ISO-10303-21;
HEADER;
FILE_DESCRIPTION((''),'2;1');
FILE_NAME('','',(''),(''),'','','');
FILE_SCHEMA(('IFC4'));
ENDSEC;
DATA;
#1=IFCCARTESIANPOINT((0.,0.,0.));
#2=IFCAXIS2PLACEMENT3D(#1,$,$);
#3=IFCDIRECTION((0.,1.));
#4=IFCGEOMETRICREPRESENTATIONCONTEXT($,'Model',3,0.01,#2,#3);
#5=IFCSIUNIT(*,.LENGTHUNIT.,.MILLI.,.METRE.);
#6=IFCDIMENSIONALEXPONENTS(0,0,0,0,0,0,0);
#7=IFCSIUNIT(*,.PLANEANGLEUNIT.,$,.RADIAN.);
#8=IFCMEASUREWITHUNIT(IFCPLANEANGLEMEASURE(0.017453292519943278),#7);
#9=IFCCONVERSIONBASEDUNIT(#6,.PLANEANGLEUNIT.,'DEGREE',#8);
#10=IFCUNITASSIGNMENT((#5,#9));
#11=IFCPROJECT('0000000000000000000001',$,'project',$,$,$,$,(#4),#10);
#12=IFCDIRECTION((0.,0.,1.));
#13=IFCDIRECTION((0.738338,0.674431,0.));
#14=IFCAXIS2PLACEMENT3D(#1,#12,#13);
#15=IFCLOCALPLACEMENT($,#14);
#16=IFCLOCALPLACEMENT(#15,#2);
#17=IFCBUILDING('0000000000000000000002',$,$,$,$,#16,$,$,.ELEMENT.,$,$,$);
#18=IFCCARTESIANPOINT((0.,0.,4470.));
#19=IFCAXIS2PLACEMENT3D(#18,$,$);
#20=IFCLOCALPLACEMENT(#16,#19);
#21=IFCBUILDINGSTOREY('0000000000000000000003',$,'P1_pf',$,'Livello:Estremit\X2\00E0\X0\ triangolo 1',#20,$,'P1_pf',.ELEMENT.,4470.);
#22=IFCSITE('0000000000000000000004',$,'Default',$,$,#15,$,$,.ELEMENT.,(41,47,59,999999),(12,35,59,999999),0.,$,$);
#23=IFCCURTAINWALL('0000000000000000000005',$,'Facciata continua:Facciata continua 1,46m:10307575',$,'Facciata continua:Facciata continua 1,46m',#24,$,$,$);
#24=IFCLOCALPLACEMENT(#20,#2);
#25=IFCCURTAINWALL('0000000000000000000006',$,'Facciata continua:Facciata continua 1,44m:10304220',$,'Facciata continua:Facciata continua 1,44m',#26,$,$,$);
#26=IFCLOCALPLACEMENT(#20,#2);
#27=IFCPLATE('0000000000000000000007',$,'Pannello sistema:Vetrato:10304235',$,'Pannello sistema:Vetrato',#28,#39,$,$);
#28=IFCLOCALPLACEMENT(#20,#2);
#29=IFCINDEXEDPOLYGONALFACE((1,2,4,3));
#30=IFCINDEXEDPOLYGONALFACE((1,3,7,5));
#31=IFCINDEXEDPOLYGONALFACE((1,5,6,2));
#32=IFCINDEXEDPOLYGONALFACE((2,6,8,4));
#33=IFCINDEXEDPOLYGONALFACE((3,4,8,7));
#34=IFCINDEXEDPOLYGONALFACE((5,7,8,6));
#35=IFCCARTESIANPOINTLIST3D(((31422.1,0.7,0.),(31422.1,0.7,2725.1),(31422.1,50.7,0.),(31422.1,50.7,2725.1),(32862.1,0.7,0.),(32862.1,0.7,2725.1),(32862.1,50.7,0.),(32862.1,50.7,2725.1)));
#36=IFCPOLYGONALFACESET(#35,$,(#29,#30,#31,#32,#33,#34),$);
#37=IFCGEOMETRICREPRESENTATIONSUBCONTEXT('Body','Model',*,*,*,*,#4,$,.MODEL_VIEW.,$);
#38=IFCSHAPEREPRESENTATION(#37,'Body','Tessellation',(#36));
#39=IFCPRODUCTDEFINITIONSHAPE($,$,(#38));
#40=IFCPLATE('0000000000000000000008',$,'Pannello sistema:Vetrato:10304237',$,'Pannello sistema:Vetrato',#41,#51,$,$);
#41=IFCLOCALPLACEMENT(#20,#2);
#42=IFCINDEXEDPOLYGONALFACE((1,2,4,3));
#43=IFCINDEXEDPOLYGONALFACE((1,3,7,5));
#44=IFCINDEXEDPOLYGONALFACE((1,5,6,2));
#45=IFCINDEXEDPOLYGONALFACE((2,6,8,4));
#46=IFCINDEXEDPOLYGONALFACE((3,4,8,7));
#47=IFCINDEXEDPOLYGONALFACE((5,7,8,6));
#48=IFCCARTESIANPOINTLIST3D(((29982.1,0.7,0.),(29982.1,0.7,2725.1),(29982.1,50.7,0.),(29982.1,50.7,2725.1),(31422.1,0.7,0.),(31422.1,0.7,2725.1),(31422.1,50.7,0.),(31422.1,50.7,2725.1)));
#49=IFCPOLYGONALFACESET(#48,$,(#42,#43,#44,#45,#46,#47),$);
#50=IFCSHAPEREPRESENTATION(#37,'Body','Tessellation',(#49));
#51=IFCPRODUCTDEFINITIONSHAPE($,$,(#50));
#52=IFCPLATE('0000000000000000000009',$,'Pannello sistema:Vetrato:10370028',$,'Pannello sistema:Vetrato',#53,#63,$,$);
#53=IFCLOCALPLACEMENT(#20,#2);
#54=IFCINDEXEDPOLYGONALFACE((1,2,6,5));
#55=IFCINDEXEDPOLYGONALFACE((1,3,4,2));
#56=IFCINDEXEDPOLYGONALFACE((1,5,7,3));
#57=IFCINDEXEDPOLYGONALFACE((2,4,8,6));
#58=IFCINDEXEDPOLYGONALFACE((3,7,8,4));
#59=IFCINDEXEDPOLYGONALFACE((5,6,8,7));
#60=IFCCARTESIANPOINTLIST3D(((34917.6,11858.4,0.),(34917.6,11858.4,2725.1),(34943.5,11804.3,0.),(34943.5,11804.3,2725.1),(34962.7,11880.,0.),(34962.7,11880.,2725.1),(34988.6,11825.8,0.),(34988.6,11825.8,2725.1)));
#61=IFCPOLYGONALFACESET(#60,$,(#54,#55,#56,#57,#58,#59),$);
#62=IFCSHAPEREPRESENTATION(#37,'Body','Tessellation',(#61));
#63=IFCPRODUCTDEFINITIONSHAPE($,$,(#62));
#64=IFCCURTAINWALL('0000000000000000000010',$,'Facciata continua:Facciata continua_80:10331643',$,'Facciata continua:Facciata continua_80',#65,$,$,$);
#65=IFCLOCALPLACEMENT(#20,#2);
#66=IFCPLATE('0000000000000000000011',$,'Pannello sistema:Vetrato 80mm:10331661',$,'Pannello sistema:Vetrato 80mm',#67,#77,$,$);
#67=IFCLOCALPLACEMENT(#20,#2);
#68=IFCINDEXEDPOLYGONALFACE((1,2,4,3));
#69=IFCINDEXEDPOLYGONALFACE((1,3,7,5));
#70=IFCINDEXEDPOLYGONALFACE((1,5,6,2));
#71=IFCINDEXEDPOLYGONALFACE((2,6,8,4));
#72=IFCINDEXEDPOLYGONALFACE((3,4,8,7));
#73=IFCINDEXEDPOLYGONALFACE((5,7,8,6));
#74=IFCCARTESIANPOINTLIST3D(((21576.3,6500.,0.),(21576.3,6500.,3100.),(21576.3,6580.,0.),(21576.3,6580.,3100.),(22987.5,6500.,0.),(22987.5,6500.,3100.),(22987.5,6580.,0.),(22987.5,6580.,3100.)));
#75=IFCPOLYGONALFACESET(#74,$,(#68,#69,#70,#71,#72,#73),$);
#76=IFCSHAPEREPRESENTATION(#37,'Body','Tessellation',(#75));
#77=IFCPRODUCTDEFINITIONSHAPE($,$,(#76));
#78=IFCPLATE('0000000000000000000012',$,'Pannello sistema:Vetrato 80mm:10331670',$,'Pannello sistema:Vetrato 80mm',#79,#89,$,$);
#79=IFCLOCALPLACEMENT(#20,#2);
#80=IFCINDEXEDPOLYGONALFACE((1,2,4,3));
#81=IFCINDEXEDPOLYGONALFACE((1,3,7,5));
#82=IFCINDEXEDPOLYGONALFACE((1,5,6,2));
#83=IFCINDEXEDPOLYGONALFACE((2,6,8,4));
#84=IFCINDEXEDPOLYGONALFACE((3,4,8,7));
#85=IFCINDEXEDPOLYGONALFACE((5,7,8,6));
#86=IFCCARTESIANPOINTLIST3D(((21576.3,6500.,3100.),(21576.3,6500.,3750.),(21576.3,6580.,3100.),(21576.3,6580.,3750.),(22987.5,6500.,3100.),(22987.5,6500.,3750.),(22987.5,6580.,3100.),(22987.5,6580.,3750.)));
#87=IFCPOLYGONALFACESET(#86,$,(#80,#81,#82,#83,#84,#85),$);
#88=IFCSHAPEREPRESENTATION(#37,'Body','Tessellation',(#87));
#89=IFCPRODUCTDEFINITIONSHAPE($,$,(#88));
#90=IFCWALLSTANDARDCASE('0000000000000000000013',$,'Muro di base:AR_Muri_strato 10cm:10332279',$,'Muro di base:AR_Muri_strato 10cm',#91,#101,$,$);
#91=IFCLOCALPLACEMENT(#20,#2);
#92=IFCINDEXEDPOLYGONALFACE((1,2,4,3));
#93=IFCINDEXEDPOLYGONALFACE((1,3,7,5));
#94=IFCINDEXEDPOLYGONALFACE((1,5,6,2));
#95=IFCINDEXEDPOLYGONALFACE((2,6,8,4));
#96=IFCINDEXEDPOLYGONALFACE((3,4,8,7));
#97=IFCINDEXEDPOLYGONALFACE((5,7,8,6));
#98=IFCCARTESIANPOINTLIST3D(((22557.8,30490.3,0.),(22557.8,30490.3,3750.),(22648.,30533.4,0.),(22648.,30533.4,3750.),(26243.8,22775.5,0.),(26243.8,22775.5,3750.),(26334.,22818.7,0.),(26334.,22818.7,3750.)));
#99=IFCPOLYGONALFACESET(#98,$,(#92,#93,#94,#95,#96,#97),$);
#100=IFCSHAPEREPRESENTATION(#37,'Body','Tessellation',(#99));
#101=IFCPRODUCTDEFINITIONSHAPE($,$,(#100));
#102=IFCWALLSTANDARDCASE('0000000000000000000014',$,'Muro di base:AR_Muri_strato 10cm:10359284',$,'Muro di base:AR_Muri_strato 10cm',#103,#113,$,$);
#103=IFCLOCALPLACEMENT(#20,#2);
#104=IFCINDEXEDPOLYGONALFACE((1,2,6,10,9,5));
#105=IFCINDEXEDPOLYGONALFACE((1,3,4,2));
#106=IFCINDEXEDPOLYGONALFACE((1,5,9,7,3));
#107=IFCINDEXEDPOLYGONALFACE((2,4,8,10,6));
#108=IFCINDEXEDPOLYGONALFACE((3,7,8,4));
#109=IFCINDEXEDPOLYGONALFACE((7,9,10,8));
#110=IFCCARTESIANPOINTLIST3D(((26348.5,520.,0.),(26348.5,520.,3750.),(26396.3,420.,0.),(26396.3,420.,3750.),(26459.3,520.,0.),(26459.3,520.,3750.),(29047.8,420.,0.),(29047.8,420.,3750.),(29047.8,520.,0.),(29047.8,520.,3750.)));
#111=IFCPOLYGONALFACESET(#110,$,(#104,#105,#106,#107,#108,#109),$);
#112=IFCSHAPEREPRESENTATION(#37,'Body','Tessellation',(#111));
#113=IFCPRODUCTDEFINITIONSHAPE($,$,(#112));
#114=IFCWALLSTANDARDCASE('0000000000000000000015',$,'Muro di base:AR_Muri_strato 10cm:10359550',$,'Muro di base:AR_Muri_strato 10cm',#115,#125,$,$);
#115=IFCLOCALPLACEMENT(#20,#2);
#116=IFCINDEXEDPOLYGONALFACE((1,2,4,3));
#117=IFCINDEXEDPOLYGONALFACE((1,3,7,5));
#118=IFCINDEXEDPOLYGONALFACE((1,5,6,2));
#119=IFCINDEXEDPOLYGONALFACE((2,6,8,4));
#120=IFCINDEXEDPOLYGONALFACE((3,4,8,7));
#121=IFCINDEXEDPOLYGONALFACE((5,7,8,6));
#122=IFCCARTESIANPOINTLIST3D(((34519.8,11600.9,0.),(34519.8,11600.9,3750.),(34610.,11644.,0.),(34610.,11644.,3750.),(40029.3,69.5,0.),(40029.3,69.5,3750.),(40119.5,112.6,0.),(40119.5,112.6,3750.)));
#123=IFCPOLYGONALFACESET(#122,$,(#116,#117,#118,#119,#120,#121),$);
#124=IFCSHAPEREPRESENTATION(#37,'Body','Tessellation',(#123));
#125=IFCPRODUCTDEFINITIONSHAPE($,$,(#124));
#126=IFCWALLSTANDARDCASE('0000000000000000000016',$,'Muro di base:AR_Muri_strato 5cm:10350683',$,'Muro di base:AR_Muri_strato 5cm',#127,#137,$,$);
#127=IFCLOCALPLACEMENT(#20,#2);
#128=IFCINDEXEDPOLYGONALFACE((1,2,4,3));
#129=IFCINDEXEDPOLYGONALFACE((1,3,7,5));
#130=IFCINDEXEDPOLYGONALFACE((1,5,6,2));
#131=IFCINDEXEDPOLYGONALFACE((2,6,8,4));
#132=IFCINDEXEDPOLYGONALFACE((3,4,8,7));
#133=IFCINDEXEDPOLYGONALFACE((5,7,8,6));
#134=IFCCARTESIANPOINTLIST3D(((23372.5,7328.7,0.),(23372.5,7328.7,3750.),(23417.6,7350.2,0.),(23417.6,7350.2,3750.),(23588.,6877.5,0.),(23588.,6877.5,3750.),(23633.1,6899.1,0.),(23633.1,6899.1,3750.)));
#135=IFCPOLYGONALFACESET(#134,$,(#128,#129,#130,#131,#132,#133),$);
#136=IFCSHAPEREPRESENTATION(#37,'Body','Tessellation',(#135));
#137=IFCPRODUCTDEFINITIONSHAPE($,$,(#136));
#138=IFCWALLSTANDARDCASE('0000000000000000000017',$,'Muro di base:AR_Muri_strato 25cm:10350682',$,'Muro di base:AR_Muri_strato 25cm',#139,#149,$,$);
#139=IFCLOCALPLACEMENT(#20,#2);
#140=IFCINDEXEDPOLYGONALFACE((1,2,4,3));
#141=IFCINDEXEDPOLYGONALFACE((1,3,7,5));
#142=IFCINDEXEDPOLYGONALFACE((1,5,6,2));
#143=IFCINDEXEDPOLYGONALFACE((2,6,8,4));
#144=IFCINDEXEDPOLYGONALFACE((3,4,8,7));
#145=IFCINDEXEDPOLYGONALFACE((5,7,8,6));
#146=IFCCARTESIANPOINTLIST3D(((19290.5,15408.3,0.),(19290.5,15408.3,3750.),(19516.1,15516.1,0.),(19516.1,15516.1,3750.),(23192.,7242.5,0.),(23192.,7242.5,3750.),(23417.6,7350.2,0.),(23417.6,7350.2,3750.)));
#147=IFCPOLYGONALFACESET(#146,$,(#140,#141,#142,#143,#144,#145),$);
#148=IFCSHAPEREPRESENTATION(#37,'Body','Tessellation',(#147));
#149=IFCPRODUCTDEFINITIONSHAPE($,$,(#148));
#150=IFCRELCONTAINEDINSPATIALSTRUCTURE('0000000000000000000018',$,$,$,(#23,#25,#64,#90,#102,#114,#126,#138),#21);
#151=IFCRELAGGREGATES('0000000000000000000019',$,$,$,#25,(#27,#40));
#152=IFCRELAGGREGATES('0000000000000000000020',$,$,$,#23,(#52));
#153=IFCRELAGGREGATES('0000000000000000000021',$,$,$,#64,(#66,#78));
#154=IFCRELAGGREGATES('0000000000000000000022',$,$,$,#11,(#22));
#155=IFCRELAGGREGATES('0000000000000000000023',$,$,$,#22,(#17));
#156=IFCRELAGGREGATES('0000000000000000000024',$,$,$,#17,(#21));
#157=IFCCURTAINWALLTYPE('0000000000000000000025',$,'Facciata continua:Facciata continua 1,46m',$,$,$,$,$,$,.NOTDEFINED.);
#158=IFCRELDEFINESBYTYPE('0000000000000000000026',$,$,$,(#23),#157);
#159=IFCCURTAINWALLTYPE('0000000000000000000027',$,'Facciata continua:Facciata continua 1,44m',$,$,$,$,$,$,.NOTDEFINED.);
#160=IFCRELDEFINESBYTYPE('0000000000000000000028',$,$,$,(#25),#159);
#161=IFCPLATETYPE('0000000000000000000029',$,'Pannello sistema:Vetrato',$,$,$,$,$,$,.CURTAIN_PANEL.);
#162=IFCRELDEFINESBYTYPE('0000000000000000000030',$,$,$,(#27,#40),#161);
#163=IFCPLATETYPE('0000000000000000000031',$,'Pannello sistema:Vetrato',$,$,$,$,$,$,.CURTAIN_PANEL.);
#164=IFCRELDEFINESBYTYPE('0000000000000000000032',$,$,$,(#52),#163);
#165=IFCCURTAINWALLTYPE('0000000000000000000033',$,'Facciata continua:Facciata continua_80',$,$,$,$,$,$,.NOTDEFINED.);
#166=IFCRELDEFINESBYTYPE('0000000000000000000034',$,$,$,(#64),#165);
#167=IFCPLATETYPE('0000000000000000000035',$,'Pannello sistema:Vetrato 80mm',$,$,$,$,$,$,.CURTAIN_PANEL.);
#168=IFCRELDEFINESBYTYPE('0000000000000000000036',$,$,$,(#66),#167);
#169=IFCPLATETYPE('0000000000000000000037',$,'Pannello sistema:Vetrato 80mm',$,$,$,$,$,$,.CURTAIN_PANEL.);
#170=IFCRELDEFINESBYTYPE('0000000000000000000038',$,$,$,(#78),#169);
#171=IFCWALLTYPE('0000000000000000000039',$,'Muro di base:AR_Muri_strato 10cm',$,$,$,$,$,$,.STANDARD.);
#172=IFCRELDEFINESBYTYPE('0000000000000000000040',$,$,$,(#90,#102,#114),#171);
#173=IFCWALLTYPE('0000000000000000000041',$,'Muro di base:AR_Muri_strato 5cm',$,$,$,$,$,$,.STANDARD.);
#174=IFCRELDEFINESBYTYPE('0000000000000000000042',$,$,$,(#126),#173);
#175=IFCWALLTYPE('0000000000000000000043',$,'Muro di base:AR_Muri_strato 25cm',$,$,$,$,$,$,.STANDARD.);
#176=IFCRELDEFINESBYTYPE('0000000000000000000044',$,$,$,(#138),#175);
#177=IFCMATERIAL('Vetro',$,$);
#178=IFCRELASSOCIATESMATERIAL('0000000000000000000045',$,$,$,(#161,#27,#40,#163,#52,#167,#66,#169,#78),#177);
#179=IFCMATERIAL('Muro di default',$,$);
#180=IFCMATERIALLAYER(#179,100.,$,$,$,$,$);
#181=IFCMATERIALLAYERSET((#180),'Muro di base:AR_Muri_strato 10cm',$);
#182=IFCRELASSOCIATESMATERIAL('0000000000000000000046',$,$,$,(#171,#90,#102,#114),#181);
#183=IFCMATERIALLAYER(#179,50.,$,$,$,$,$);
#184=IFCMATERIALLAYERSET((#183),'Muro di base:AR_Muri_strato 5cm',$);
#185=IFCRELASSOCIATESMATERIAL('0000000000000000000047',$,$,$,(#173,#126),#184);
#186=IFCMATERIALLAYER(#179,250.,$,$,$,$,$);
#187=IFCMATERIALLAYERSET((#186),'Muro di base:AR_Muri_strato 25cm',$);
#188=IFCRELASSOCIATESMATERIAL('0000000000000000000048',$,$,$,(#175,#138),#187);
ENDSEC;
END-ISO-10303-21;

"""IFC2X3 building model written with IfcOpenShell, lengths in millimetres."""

from ifc_helpers import new_model, entity, si_unit, converted_unit, direction, frame, frame_2d, origin, origin_2d_with_axis, place, context, subcontext, project, spatial, polyline, rectangle, outline, extrude, source, transform, mapped, material, layer, layer_set, layer_usage, type_object, type_shapes, element, aggregate, save


model = new_model("IFC2X3")

# Units and contexts
model_context = context("Model", 3, precision=0.01, world=origin(), true_north=direction((0.0, 1.0)))
body_context = subcontext(model_context, "Body", "Model", "MODEL_VIEW")
ifc_project = project(units=[si_unit("LENGTHUNIT", "METRE", prefix="MILLI"), converted_unit("PLANEANGLEUNIT", "DEGREE", entity("IfcPlaneAngleMeasure", 0.017453292519943278), si_unit("PLANEANGLEUNIT", "RADIAN"), dimensions=[0, 0, 0, 0, 0, 0, 0])], contexts=[model_context])

# Site, building, storey
site_placement = place(None, frame((0.0, 0.0, 0.0), z_axis=(0.0, 0.0, 1.0), x_axis=(0.738338, 0.674431, 0.0)))
site = spatial("IfcSite", under=ifc_project, at=site_placement, Name="Default", CompositionType="ELEMENT", RefLatitude=(41, 47, 59, 999999), RefLongitude=(12, 35, 59, 999999), RefElevation=0.0)
building_placement = place(site_placement, origin())
building = spatial("IfcBuilding", under=site, at=building_placement, CompositionType="ELEMENT")
storey_placement = place(building_placement, frame((0.0, 0.0, 4470.0)))
storey = spatial("IfcBuildingStorey", under=building, at=storey_placement, Name="P1_pf", ObjectType="Livello:Estremità triangolo 1", LongName="P1_pf", CompositionType="ELEMENT", Elevation=4470.0)

# Curtain walls, plates
curtain_wall_type_1 = type_object("IfcCurtainWallType", Name="Facciata continua:Facciata continua 1,46m", PredefinedType="NOTDEFINED")
curtain_wall_1_placement = place(storey_placement, frame((0.0, 0.0, -4470.0)))
curtain_wall_1 = element("IfcCurtainWall", 1, at=curtain_wall_1_placement, inside=storey, type_object=curtain_wall_type_1, Name="Facciata continua:Facciata continua 1,46m:10307575", ObjectType="Facciata continua:Facciata continua 1,46m")
ifc_material_1 = material(Name="Vetro")
curtain_wall_type_2 = type_object("IfcCurtainWallType", Name="Facciata continua:Facciata continua 1,44m", PredefinedType="NOTDEFINED")
curtain_wall_2_placement = place(storey_placement, frame((0.0, 0.0, -4470.0)))
curtain_wall_2 = element("IfcCurtainWall", 2, at=curtain_wall_2_placement, inside=storey, type_object=curtain_wall_type_2, Name="Facciata continua:Facciata continua 1,44m:10304220", ObjectType="Facciata continua:Facciata continua 1,44m")
plate_type_1 = type_object("IfcPlateType", Name="Pannello sistema:Vetrato", PredefinedType="CURTAIN_PANEL", material=ifc_material_1)
shared_shape_1 = source(origin(), body_context, "Body", "SweptSolid", [
    extrude(rectangle(XDim=50.0, YDim=1440.0, at=origin_2d_with_axis()), frame((0.0, -25.0, 0.0), z_axis=(0.0, 0.0, 1.0), x_axis=(0.0, 1.0, 0.0)), (0.0, 0.0, 1.0), 2725.1),
])
type_shapes(plate_type_1, [shared_shape_1])
plate_1_placement = place(curtain_wall_2_placement, frame((32142.1, 0.7, 4470.0), z_axis=(0.0, 0.0, 1.0), x_axis=(-1.0, 0.0, 0.0)))
plate_1 = element("IfcPlate", 3, at=plate_1_placement, type_object=plate_type_1, material=ifc_material_1, Name="Pannello sistema:Vetrato:10304235", ObjectType="Pannello sistema:Vetrato", context=body_context, shape_type="MappedRepresentation", body=[
    mapped(shared_shape_1, transform((0.0, 0.0, 0.0), scale=1.0)),
])
plate_2_placement = place(curtain_wall_2_placement, frame((30702.1, 0.7, 4470.0), z_axis=(0.0, 0.0, 1.0), x_axis=(-1.0, 0.0, 0.0)))
plate_2 = element("IfcPlate", 4, at=plate_2_placement, type_object=plate_type_1, material=ifc_material_1, Name="Pannello sistema:Vetrato:10304237", ObjectType="Pannello sistema:Vetrato", context=body_context, shape_type="MappedRepresentation", body=[
    mapped(shared_shape_1, transform((0.0, 0.0, 0.0), scale=1.0)),
])
aggregate(curtain_wall_2, [plate_1, plate_2])

# Plate
plate_type_2 = type_object("IfcPlateType", Name="Pannello sistema:Vetrato", PredefinedType="CURTAIN_PANEL", material=ifc_material_1)
shared_shape_2 = source(origin(), body_context, "Body", "SweptSolid", [
    extrude(rectangle(XDim=50.0, YDim=60.0, at=frame_2d((0.0, 0.0), x_axis=(1.0, 0.0))), frame((0.0, -25.0, 0.0), z_axis=(0.0, 0.0, 1.0), x_axis=(0.0, 1.0, 0.0)), (0.0, 0.0, 1.0), 2725.1),
])
type_shapes(plate_type_2, [shared_shape_2])
plate_3_placement = place(curtain_wall_1_placement, frame((34975.6, 11852.9, 4470.0), z_axis=(0.0, 0.0, 1.0), x_axis=(0.431105, -0.902302, 0.0)))
plate_3 = element("IfcPlate", 5, at=plate_3_placement, type_object=plate_type_2, material=ifc_material_1, Name="Pannello sistema:Vetrato:10370028", ObjectType="Pannello sistema:Vetrato", context=body_context, shape_type="MappedRepresentation", body=[
    mapped(shared_shape_2, transform((0.0, 0.0, 0.0), scale=1.0)),
])
aggregate(curtain_wall_1, [plate_3])

# Curtain wall, plates
curtain_wall_type_3 = type_object("IfcCurtainWallType", Name="Facciata continua:Facciata continua_80", PredefinedType="NOTDEFINED")
curtain_wall_3_placement = place(storey_placement, frame((0.0, 0.0, -4470.0)))
curtain_wall_3 = element("IfcCurtainWall", 6, at=curtain_wall_3_placement, inside=storey, type_object=curtain_wall_type_3, Name="Facciata continua:Facciata continua_80:10331643", ObjectType="Facciata continua:Facciata continua_80")
plate_type_3 = type_object("IfcPlateType", Name="Pannello sistema:Vetrato 80mm", PredefinedType="CURTAIN_PANEL", material=ifc_material_1)
shared_shape_3 = source(origin(), body_context, "Body", "SweptSolid", [
    extrude(rectangle(XDim=80.0, YDim=1411.2, at=origin_2d_with_axis()), frame((0.0, -40.0, 0.0), z_axis=(0.0, 0.0, 1.0), x_axis=(0.0, 1.0, 0.0)), (0.0, 0.0, 1.0), 3100.0),
])
type_shapes(plate_type_3, [shared_shape_3])
plate_4_placement = place(curtain_wall_3_placement, frame((22281.9, 6580.0, 4470.0)))
plate_4 = element("IfcPlate", 7, at=plate_4_placement, type_object=plate_type_3, material=ifc_material_1, Name="Pannello sistema:Vetrato 80mm:10331661", ObjectType="Pannello sistema:Vetrato 80mm", context=body_context, shape_type="MappedRepresentation", body=[
    mapped(shared_shape_3, transform((0.0, 0.0, 0.0), scale=1.0)),
])
plate_type_4 = type_object("IfcPlateType", Name="Pannello sistema:Vetrato 80mm", PredefinedType="CURTAIN_PANEL", material=ifc_material_1)
shared_shape_4 = source(origin(), body_context, "Body", "SweptSolid", [
    extrude(rectangle(XDim=80.0, YDim=1411.2, at=origin_2d_with_axis()), frame((0.0, -40.0, 0.0), z_axis=(0.0, 0.0, 1.0), x_axis=(0.0, 1.0, 0.0)), (0.0, 0.0, 1.0), 650.0),
])
type_shapes(plate_type_4, [shared_shape_4])
plate_5_placement = place(curtain_wall_3_placement, frame((22281.9, 6580.0, 7570.0)))
plate_5 = element("IfcPlate", 8, at=plate_5_placement, type_object=plate_type_4, material=ifc_material_1, Name="Pannello sistema:Vetrato 80mm:10331670", ObjectType="Pannello sistema:Vetrato 80mm", context=body_context, shape_type="MappedRepresentation", body=[
    mapped(shared_shape_4, transform((0.0, 0.0, 0.0), scale=1.0)),
])
aggregate(curtain_wall_3, [plate_4, plate_5])

# Walls
ifc_material_2 = material(Name="Muro di default")
ifc_layer_1 = layer(ifc_material_2, 100.0)
ifc_layer_set_1 = layer_set([ifc_layer_1], Name="Muro di base:AR_Muri_strato 10cm")
ifc_layer_usage_1 = layer_usage(ifc_layer_set_1, "AXIS2", "NEGATIVE", 50.0)
wall_type_1 = type_object("IfcWallType", Name="Muro di base:AR_Muri_strato 10cm", PredefinedType="STANDARD", material=ifc_layer_set_1)
wall_1_placement = place(storey_placement, frame((26288.9, 22797.1, 0.0), z_axis=(0.0, 0.0, 1.0), x_axis=(-0.431105, 0.902302, 0.0)))
element("IfcWallStandardCase", 9, at=wall_1_placement, inside=storey, type_object=wall_type_1, material=ifc_layer_usage_1, Name="Muro di base:AR_Muri_strato 10cm:10332279", ObjectType="Muro di base:AR_Muri_strato 10cm", context=body_context, shape_type="SweptSolid", body=[
    extrude(rectangle(XDim=8550.1, YDim=100.0, at=frame_2d((4275.1, 0.0), x_axis=(-1.0, 0.0))), origin(), (0.0, 0.0, 1.0), 3750.0),
])
ifc_layer_usage_2 = layer_usage(ifc_layer_set_1, "AXIS2", "NEGATIVE", 50.0)
wall_2_placement = place(storey_placement, frame((29047.8, 470.0, 0.0), z_axis=(0.0, 0.0, 1.0), x_axis=(-1.0, 0.0, 0.0)))
element("IfcWallStandardCase", 10, at=wall_2_placement, inside=storey, type_object=wall_type_1, material=ifc_layer_usage_2, Name="Muro di base:AR_Muri_strato 10cm:10359284", ObjectType="Muro di base:AR_Muri_strato 10cm", context=body_context, shape_type="SweptSolid", body=[
    extrude(outline(polyline([(2699.3, -50.0), (2651.5, 50.0), (0.0, 50.0), (0.0, -50.0), (2588.5, -50.0), (2699.3, -50.0)])), origin(), (0.0, 0.0, 1.0), 3750.0),
])
ifc_layer_usage_3 = layer_usage(ifc_layer_set_1, "AXIS2", "NEGATIVE", 50.0)
wall_3_placement = place(storey_placement, frame((34564.9, 11622.5, 0.0), z_axis=(0.0, 0.0, 1.0), x_axis=(0.431105, -0.902302, 0.0)))
element("IfcWallStandardCase", 11, at=wall_3_placement, inside=storey, type_object=wall_type_1, material=ifc_layer_usage_3, Name="Muro di base:AR_Muri_strato 10cm:10359550", ObjectType="Muro di base:AR_Muri_strato 10cm", context=body_context, shape_type="SweptSolid", body=[
    extrude(rectangle(XDim=12780.0, YDim=100.0, at=frame_2d((6390.0, 0.0), x_axis=(-1.0, 0.0))), origin(), (0.0, 0.0, 1.0), 3750.0),
])
ifc_layer_2 = layer(ifc_material_2, 50.0)
ifc_layer_set_2 = layer_set([ifc_layer_2], Name="Muro di base:AR_Muri_strato 5cm")
ifc_layer_usage_4 = layer_usage(ifc_layer_set_2, "AXIS2", "NEGATIVE", 25.0)
wall_type_2 = type_object("IfcWallType", Name="Muro di base:AR_Muri_strato 5cm", PredefinedType="STANDARD", material=ifc_layer_set_2)
wall_4_placement = place(storey_placement, frame((23610.6, 6888.3, 0.0), z_axis=(0.0, 0.0, 1.0), x_axis=(-0.431105, 0.902302, 0.0)))
element("IfcWallStandardCase", 12, at=wall_4_placement, inside=storey, type_object=wall_type_2, material=ifc_layer_usage_4, Name="Muro di base:AR_Muri_strato 5cm:10350683", ObjectType="Muro di base:AR_Muri_strato 5cm", context=body_context, shape_type="SweptSolid", body=[
    extrude(rectangle(XDim=500.0, YDim=50.0, at=frame_2d((250.0, 0.0), x_axis=(-1.0, 0.0))), origin(), (0.0, 0.0, 1.0), 3750.0),
])
ifc_layer_3 = layer(ifc_material_2, 250.0)
ifc_layer_set_3 = layer_set([ifc_layer_3], Name="Muro di base:AR_Muri_strato 25cm")
ifc_layer_usage_5 = layer_usage(ifc_layer_set_3, "AXIS2", "NEGATIVE", 125.0)
wall_type_3 = type_object("IfcWallType", Name="Muro di base:AR_Muri_strato 25cm", PredefinedType="STANDARD", material=ifc_layer_set_3)
wall_5_placement = place(storey_placement, frame((23304.8, 7296.4, 0.0), z_axis=(0.0, 0.0, 1.0), x_axis=(-0.431105, 0.902302, 0.0)))
element("IfcWallStandardCase", 13, at=wall_5_placement, inside=storey, type_object=wall_type_3, material=ifc_layer_usage_5, Name="Muro di base:AR_Muri_strato 25cm:10350682", ObjectType="Muro di base:AR_Muri_strato 25cm", context=body_context, shape_type="SweptSolid", body=[
    extrude(rectangle(XDim=9050.0, YDim=250.0, at=frame_2d((4525.0, 0.0), x_axis=(-1.0, 0.0))), origin(), (0.0, 0.0, 1.0), 3750.0),
])

save(model, "model.ifc")
